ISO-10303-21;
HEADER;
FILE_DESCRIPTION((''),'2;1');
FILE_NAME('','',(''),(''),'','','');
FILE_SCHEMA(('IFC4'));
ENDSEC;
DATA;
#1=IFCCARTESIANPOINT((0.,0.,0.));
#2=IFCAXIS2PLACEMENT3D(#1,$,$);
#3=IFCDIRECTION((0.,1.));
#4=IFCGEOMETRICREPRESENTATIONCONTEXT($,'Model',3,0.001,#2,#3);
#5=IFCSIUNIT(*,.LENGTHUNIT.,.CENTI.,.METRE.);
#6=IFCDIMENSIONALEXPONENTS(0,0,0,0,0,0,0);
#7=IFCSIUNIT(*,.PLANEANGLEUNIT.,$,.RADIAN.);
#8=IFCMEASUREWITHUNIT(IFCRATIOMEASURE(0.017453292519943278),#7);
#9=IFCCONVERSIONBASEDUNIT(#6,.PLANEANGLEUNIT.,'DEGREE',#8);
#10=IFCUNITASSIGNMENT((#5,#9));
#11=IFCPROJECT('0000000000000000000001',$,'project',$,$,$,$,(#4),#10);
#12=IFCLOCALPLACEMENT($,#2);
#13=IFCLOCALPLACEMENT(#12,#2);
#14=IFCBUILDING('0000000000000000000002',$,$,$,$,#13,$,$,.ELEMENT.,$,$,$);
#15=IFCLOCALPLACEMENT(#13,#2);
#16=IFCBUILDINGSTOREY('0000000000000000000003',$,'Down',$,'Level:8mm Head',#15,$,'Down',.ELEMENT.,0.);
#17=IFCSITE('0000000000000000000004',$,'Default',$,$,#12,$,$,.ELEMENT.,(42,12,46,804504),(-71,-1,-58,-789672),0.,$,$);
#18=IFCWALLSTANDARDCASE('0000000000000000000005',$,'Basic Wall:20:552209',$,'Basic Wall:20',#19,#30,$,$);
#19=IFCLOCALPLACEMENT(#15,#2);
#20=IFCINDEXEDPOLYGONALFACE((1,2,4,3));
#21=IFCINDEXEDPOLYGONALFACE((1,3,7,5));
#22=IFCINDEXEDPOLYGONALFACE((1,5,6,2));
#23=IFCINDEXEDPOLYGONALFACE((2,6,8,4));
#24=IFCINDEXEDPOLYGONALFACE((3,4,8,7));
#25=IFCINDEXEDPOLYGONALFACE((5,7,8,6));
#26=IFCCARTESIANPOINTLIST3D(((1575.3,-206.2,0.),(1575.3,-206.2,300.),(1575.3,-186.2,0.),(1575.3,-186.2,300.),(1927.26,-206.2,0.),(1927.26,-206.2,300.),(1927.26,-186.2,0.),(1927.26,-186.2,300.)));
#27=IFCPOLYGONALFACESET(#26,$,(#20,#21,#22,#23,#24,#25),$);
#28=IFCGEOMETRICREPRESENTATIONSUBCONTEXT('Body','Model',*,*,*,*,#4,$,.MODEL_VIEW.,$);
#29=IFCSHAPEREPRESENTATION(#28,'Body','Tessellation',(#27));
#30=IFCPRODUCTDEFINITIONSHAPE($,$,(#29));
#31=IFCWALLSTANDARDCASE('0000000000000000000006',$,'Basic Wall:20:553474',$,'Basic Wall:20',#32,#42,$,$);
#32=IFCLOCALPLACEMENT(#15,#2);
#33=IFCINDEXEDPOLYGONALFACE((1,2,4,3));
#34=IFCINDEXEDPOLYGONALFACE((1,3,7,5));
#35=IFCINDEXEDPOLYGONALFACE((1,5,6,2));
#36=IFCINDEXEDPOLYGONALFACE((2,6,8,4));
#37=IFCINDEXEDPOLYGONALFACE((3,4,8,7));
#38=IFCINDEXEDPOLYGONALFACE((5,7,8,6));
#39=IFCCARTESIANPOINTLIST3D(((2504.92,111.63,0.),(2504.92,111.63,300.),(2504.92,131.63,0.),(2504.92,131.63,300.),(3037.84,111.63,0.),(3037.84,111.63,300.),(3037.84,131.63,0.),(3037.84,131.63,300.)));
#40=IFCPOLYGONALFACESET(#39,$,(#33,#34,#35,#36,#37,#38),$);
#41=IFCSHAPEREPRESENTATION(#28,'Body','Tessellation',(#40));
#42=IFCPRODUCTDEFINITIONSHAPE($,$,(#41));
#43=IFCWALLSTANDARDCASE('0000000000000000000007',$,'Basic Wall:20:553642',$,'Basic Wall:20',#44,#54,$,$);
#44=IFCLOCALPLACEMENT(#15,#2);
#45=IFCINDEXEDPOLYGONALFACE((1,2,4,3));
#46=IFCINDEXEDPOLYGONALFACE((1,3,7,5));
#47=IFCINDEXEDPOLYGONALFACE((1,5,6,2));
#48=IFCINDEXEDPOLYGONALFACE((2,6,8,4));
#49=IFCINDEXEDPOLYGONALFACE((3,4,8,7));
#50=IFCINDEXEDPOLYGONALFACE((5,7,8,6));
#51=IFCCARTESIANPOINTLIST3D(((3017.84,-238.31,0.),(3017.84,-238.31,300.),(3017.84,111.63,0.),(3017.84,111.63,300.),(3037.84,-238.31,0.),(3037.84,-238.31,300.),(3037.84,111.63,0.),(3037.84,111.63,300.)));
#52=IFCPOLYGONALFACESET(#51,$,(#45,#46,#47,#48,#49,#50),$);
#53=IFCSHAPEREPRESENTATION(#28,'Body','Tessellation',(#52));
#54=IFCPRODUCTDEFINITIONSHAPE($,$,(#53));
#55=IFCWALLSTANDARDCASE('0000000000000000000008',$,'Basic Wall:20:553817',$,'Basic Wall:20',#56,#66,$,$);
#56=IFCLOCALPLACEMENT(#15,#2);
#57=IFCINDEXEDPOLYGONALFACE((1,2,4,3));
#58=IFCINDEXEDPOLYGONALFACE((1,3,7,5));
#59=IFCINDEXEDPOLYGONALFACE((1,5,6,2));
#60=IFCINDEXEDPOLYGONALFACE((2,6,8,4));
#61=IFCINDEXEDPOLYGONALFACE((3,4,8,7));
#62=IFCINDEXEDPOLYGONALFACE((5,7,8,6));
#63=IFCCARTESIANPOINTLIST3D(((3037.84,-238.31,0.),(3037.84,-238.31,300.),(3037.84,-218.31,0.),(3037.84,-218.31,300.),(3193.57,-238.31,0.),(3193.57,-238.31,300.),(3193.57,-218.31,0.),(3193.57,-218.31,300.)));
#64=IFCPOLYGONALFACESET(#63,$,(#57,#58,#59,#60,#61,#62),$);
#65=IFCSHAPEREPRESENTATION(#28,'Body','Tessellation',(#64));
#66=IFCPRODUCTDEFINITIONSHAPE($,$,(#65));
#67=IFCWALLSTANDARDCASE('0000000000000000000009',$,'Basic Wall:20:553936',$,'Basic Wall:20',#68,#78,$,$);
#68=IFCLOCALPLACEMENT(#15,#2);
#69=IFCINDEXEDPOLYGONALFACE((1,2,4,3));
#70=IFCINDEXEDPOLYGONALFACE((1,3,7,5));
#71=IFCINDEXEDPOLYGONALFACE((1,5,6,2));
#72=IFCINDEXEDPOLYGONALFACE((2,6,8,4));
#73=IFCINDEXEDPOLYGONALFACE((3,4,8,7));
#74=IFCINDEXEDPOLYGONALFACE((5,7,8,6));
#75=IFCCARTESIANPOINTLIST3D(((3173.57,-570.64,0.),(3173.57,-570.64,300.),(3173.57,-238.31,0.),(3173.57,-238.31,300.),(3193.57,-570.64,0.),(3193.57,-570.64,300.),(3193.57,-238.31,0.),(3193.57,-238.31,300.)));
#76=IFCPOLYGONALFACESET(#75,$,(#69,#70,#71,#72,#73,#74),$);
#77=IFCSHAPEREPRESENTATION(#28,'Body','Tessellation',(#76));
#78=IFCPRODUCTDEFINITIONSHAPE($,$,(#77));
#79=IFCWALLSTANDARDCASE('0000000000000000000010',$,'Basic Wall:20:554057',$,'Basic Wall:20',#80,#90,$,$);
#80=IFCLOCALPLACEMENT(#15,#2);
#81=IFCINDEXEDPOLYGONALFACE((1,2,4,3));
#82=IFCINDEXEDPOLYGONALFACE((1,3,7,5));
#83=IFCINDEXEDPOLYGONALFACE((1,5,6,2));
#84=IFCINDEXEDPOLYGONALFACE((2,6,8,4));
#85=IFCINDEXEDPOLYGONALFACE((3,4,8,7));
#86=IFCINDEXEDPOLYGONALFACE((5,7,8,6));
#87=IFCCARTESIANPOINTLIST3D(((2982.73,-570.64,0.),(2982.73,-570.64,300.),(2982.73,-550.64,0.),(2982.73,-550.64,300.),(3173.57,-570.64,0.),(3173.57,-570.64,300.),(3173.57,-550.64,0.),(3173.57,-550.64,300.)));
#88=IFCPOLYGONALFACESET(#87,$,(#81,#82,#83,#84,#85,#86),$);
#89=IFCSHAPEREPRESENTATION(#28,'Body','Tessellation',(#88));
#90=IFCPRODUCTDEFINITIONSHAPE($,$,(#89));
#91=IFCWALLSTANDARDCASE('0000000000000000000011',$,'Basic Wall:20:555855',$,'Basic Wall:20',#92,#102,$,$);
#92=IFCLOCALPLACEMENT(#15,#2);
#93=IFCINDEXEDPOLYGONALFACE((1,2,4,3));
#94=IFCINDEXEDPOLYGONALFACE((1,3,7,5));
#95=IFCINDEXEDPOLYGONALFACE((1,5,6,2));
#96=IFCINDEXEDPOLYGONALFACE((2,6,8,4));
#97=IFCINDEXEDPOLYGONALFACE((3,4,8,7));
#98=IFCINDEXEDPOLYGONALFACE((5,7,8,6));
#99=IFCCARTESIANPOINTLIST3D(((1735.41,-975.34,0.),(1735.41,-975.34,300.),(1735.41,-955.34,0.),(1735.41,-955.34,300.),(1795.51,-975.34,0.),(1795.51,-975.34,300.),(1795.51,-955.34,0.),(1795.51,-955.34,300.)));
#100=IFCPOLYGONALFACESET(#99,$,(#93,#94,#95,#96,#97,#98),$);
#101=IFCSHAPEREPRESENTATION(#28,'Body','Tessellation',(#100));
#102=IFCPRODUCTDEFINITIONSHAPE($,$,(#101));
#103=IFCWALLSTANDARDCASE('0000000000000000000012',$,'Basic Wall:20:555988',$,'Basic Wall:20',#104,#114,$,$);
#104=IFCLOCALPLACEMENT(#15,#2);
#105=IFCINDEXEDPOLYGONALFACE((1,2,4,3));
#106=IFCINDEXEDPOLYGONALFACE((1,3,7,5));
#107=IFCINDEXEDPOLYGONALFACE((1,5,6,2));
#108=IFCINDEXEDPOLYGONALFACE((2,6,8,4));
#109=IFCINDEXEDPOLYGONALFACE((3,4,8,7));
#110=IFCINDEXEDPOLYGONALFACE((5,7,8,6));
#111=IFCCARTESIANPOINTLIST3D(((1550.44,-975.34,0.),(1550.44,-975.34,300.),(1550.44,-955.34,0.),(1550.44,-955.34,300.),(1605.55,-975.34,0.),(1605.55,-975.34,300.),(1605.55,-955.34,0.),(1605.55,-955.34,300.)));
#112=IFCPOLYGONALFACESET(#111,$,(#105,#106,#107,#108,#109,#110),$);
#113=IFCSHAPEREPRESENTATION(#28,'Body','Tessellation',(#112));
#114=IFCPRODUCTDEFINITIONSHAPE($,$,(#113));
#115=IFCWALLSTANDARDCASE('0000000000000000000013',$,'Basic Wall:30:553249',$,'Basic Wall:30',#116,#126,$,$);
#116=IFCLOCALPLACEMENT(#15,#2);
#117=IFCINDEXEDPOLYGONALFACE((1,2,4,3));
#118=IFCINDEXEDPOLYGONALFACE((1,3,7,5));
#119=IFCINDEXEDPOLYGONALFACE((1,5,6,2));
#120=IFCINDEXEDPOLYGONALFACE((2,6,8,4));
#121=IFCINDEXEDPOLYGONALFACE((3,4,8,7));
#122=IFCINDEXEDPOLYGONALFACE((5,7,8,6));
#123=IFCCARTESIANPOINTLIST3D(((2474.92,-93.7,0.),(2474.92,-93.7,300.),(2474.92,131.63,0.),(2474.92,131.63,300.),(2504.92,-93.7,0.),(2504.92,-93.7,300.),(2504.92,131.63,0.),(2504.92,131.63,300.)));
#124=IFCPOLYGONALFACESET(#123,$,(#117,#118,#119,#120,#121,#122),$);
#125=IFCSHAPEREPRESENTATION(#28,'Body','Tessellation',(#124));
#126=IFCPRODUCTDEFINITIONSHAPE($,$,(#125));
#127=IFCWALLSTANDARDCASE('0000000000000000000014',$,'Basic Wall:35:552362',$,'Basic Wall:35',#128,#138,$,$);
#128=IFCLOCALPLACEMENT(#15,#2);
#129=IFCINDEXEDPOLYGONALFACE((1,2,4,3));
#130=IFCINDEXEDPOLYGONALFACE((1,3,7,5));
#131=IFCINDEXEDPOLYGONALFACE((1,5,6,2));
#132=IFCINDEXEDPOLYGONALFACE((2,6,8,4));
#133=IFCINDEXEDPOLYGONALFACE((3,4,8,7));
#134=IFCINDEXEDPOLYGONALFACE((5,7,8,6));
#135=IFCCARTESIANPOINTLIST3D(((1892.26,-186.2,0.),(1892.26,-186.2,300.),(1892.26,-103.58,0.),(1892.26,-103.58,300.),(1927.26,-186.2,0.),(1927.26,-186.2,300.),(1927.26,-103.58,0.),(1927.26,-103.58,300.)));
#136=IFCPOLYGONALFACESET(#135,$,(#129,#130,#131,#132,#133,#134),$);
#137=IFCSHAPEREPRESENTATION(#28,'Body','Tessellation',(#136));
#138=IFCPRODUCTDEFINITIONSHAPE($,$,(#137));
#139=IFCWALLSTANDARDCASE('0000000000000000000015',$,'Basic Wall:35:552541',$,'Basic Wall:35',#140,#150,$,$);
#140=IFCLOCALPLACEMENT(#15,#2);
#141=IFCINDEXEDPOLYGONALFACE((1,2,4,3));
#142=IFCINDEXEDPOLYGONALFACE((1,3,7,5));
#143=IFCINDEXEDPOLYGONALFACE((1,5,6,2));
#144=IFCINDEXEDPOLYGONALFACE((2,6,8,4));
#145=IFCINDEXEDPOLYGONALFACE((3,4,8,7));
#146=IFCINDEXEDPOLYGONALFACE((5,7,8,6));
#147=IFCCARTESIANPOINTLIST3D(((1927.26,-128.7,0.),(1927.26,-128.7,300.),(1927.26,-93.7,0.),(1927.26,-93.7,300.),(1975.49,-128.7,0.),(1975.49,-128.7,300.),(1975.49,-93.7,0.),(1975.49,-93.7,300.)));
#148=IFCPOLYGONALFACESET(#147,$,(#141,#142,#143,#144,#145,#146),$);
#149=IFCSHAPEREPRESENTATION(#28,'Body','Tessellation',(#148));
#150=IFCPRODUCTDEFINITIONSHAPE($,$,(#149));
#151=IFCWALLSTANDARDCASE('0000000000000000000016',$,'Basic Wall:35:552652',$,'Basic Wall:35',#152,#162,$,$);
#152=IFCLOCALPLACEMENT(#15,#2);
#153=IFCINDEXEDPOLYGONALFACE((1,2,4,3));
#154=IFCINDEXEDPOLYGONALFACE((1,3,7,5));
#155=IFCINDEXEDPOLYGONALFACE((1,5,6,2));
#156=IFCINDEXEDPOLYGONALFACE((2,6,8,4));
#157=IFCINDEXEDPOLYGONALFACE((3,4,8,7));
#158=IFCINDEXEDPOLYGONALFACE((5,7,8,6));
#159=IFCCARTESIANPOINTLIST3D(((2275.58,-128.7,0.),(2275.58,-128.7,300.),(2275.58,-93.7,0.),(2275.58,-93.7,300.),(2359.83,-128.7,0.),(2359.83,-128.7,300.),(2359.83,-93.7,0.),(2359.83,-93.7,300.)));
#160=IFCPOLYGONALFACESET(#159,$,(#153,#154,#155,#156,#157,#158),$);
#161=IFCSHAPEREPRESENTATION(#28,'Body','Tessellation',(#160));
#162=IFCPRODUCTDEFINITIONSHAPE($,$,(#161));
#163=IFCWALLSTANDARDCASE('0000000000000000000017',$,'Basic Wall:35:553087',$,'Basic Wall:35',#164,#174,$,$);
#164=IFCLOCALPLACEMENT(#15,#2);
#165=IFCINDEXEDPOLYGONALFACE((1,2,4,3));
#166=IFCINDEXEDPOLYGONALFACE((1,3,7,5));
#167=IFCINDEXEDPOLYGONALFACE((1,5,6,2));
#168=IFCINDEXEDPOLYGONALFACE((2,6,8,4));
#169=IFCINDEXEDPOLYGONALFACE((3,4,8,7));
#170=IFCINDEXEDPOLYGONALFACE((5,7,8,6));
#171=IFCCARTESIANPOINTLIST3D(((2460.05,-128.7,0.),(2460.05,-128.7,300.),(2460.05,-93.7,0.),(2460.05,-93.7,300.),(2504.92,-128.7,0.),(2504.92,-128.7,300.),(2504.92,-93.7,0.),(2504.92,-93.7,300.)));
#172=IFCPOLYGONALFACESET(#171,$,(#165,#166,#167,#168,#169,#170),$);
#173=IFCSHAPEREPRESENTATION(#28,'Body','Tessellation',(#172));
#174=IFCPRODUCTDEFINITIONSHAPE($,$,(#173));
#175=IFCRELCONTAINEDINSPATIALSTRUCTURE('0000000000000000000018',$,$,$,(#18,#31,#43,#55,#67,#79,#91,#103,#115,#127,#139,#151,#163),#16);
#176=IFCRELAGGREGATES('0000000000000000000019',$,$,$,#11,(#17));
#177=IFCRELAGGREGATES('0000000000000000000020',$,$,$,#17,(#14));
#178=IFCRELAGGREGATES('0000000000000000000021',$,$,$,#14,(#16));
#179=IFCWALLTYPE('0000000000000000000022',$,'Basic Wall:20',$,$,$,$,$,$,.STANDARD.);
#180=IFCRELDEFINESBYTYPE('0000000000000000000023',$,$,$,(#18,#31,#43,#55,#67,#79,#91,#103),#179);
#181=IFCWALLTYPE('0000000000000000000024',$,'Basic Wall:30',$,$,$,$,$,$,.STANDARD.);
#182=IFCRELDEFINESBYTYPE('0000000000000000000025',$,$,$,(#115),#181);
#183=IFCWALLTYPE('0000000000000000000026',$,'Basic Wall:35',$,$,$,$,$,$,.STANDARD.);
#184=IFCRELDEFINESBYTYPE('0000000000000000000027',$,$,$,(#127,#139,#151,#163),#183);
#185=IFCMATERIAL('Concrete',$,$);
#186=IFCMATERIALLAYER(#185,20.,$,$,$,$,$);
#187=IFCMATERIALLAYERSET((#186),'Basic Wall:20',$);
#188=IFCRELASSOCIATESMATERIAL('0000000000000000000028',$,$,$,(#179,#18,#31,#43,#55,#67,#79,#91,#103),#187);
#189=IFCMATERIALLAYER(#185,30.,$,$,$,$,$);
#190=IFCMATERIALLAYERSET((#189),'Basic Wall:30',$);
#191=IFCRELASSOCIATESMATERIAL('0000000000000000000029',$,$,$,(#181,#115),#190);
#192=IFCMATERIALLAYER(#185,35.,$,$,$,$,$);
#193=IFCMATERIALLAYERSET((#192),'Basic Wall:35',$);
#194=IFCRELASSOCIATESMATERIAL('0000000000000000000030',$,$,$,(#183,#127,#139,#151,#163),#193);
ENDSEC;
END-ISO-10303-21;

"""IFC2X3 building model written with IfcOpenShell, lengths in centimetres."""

from ifc_helpers import new_model, entity, si_unit, converted_unit, direction, frame, frame_2d, origin, place, context, subcontext, project, spatial, rectangle, extrude, material, layer, layer_set, layer_usage, type_object, element, save


model = new_model("IFC2X3")

# Units and contexts
model_context = context("Model", 3, precision=0.001, world=origin(), true_north=direction((0.0, 1.0)))
body_context = subcontext(model_context, "Body", "Model", "MODEL_VIEW")
ifc_project = project(units=[si_unit("LENGTHUNIT", "METRE", prefix="CENTI"), converted_unit("PLANEANGLEUNIT", "DEGREE", entity("IfcRatioMeasure", 0.017453292519943278), si_unit("PLANEANGLEUNIT", "RADIAN"), dimensions=[0, 0, 0, 0, 0, 0, 0])], contexts=[model_context])

# Site, building, storey
site_placement = place(None, origin())
site = spatial("IfcSite", under=ifc_project, at=site_placement, Name="Default", CompositionType="ELEMENT", RefLatitude=(42, 12, 46, 804504), RefLongitude=(-71, -1, -58, -789672), RefElevation=0.0)
building_placement = place(site_placement, origin())
building = spatial("IfcBuilding", under=site, at=building_placement, CompositionType="ELEMENT")
storey_placement = place(building_placement, origin())
storey = spatial("IfcBuildingStorey", under=building, at=storey_placement, Name="Down", ObjectType="Level:8mm Head", LongName="Down", CompositionType="ELEMENT", Elevation=0.0)

# Walls
ifc_material = material(Name="Concrete")
ifc_layer_1 = layer(ifc_material, 20.0)
ifc_layer_set_1 = layer_set([ifc_layer_1], Name="Basic Wall:20")
ifc_layer_usage_1 = layer_usage(ifc_layer_set_1, "AXIS2", "POSITIVE", -10.0)
wall_type_1 = type_object("IfcWallType", Name="Basic Wall:20", PredefinedType="STANDARD", material=ifc_layer_set_1)
wall_1_placement = place(storey_placement, frame((1575.3, -196.2, 0.0)))
element("IfcWallStandardCase", 1, at=wall_1_placement, inside=storey, type_object=wall_type_1, material=ifc_layer_usage_1, Name="Basic Wall:20:552209", ObjectType="Basic Wall:20", context=body_context, shape_type="SweptSolid", body=[
    extrude(rectangle(XDim=351.96, YDim=20.0, at=frame_2d((175.98, 0.0), x_axis=(-1.0, 0.0))), origin(), (0.0, 0.0, 1.0), 300.0),
])
ifc_layer_usage_2 = layer_usage(ifc_layer_set_1, "AXIS2", "NEGATIVE", 10.0)
wall_2_placement = place(storey_placement, frame((2504.92, 121.63, 0.0)))
element("IfcWallStandardCase", 2, at=wall_2_placement, inside=storey, type_object=wall_type_1, material=ifc_layer_usage_2, Name="Basic Wall:20:553474", ObjectType="Basic Wall:20", context=body_context, shape_type="SweptSolid", body=[
    extrude(rectangle(XDim=532.92, YDim=20.0, at=frame_2d((266.46, 0.0), x_axis=(-1.0, 0.0))), origin(), (0.0, 0.0, 1.0), 300.0),
])
ifc_layer_usage_3 = layer_usage(ifc_layer_set_1, "AXIS2", "NEGATIVE", 10.0)
wall_3_placement = place(storey_placement, frame((3027.84, 111.63, 0.0), z_axis=(0.0, 0.0, 1.0), x_axis=(0.0, -1.0, 0.0)))
element("IfcWallStandardCase", 3, at=wall_3_placement, inside=storey, type_object=wall_type_1, material=ifc_layer_usage_3, Name="Basic Wall:20:553642", ObjectType="Basic Wall:20", context=body_context, shape_type="SweptSolid", body=[
    extrude(rectangle(XDim=349.94, YDim=20.0, at=frame_2d((174.97, 0.0), x_axis=(-1.0, 0.0))), origin(), (0.0, 0.0, 1.0), 300.0),
])
ifc_layer_usage_4 = layer_usage(ifc_layer_set_1, "AXIS2", "POSITIVE", -10.0)
wall_4_placement = place(storey_placement, frame((3037.84, -228.31, 0.0)))
element("IfcWallStandardCase", 4, at=wall_4_placement, inside=storey, type_object=wall_type_1, material=ifc_layer_usage_4, Name="Basic Wall:20:553817", ObjectType="Basic Wall:20", context=body_context, shape_type="SweptSolid", body=[
    extrude(rectangle(XDim=155.73, YDim=20.0, at=frame_2d((77.86, 0.0), x_axis=(-1.0, 0.0))), origin(), (0.0, 0.0, 1.0), 300.0),
])
ifc_layer_usage_5 = layer_usage(ifc_layer_set_1, "AXIS2", "NEGATIVE", 10.0)
wall_5_placement = place(storey_placement, frame((3183.57, -238.31, 0.0), z_axis=(0.0, 0.0, 1.0), x_axis=(0.0, -1.0, 0.0)))
element("IfcWallStandardCase", 5, at=wall_5_placement, inside=storey, type_object=wall_type_1, material=ifc_layer_usage_5, Name="Basic Wall:20:553936", ObjectType="Basic Wall:20", context=body_context, shape_type="SweptSolid", body=[
    extrude(rectangle(XDim=332.32, YDim=20.0, at=frame_2d((166.16, 0.0), x_axis=(-1.0, 0.0))), origin(), (0.0, 0.0, 1.0), 300.0),
])
ifc_layer_usage_6 = layer_usage(ifc_layer_set_1, "AXIS2", "NEGATIVE", 10.0)
wall_6_placement = place(storey_placement, frame((3173.57, -560.64, 0.0), z_axis=(0.0, 0.0, 1.0), x_axis=(-1.0, 0.0, 0.0)))
element("IfcWallStandardCase", 6, at=wall_6_placement, inside=storey, type_object=wall_type_1, material=ifc_layer_usage_6, Name="Basic Wall:20:554057", ObjectType="Basic Wall:20", context=body_context, shape_type="SweptSolid", body=[
    extrude(rectangle(XDim=190.84, YDim=20.0, at=frame_2d((95.42, 0.0), x_axis=(-1.0, 0.0))), origin(), (0.0, 0.0, 1.0), 300.0),
])
ifc_layer_usage_7 = layer_usage(ifc_layer_set_1, "AXIS2", "NEGATIVE", 10.0)
wall_7_placement = place(storey_placement, frame((1795.51, -965.34, 0.0), z_axis=(0.0, 0.0, 1.0), x_axis=(-1.0, 0.0, 0.0)))
element("IfcWallStandardCase", 7, at=wall_7_placement, inside=storey, type_object=wall_type_1, material=ifc_layer_usage_7, Name="Basic Wall:20:555855", ObjectType="Basic Wall:20", context=body_context, shape_type="SweptSolid", body=[
    extrude(rectangle(XDim=60.1, YDim=20.0, at=frame_2d((30.05, 0.0), x_axis=(-1.0, 0.0))), origin(), (0.0, 0.0, 1.0), 300.0),
])
ifc_layer_usage_8 = layer_usage(ifc_layer_set_1, "AXIS2", "POSITIVE", -10.0)
wall_8_placement = place(storey_placement, frame((1605.55, -965.34, 0.0), z_axis=(0.0, 0.0, 1.0), x_axis=(-1.0, 0.0, 0.0)))
element("IfcWallStandardCase", 8, at=wall_8_placement, inside=storey, type_object=wall_type_1, material=ifc_layer_usage_8, Name="Basic Wall:20:555988", ObjectType="Basic Wall:20", context=body_context, shape_type="SweptSolid", body=[
    extrude(rectangle(XDim=55.11, YDim=20.0, at=frame_2d((27.56, 0.0), x_axis=(-1.0, 0.0))), origin(), (0.0, 0.0, 1.0), 300.0),
])
ifc_layer_2 = layer(ifc_material, 30.0)
ifc_layer_set_2 = layer_set([ifc_layer_2], Name="Basic Wall:30")
ifc_layer_usage_9 = layer_usage(ifc_layer_set_2, "AXIS2", "POSITIVE", -15.0)
wall_type_2 = type_object("IfcWallType", Name="Basic Wall:30", PredefinedType="STANDARD", material=ifc_layer_set_2)
wall_9_placement = place(storey_placement, frame((2489.92, -93.7, 0.0), z_axis=(0.0, 0.0, 1.0), x_axis=(0.0, 1.0, 0.0)))
element("IfcWallStandardCase", 9, at=wall_9_placement, inside=storey, type_object=wall_type_2, material=ifc_layer_usage_9, Name="Basic Wall:30:553249", ObjectType="Basic Wall:30", context=body_context, shape_type="SweptSolid", body=[
    extrude(rectangle(XDim=225.33, YDim=30.0, at=frame_2d((112.67, 0.0), x_axis=(-1.0, 0.0))), origin(), (0.0, 0.0, 1.0), 300.0),
])
ifc_layer_3 = layer(ifc_material, 35.0)
ifc_layer_set_3 = layer_set([ifc_layer_3], Name="Basic Wall:35")
ifc_layer_usage_10 = layer_usage(ifc_layer_set_3, "AXIS2", "POSITIVE", -17.5)
wall_type_3 = type_object("IfcWallType", Name="Basic Wall:35", PredefinedType="STANDARD", material=ifc_layer_set_3)
wall_10_placement = place(storey_placement, frame((1909.76, -186.2, 0.0), z_axis=(0.0, 0.0, 1.0), x_axis=(0.0, 1.0, 0.0)))
element("IfcWallStandardCase", 10, at=wall_10_placement, inside=storey, type_object=wall_type_3, material=ifc_layer_usage_10, Name="Basic Wall:35:552362", ObjectType="Basic Wall:35", context=body_context, shape_type="SweptSolid", body=[
    extrude(rectangle(XDim=82.62, YDim=35.0, at=frame_2d((41.31, 0.0), x_axis=(-1.0, 0.0))), origin(), (0.0, 0.0, 1.0), 300.0),
])
ifc_layer_usage_11 = layer_usage(ifc_layer_set_3, "AXIS2", "POSITIVE", -17.5)
wall_11_placement = place(storey_placement, frame((1975.49, -111.2, 0.0), z_axis=(0.0, 0.0, 1.0), x_axis=(-1.0, 0.0, 0.0)))
element("IfcWallStandardCase", 11, at=wall_11_placement, inside=storey, type_object=wall_type_3, material=ifc_layer_usage_11, Name="Basic Wall:35:552541", ObjectType="Basic Wall:35", context=body_context, shape_type="SweptSolid", body=[
    extrude(rectangle(XDim=48.24, YDim=35.0, at=frame_2d((24.12, 0.0), x_axis=(-1.0, 0.0))), origin(), (0.0, 0.0, 1.0), 300.0),
])
ifc_layer_usage_12 = layer_usage(ifc_layer_set_3, "AXIS2", "NEGATIVE", 17.5)
wall_12_placement = place(storey_placement, frame((2275.58, -111.2, 0.0)))
element("IfcWallStandardCase", 12, at=wall_12_placement, inside=storey, type_object=wall_type_3, material=ifc_layer_usage_12, Name="Basic Wall:35:552652", ObjectType="Basic Wall:35", context=body_context, shape_type="SweptSolid", body=[
    extrude(rectangle(XDim=84.25, YDim=35.0, at=frame_2d((42.12, 0.0), x_axis=(-1.0, 0.0))), origin(), (0.0, 0.0, 1.0), 300.0),
])
ifc_layer_usage_13 = layer_usage(ifc_layer_set_3, "AXIS2", "NEGATIVE", 17.5)
wall_13_placement = place(storey_placement, frame((2504.92, -111.2, 0.0), z_axis=(0.0, 0.0, 1.0), x_axis=(-1.0, 0.0, 0.0)))
element("IfcWallStandardCase", 13, at=wall_13_placement, inside=storey, type_object=wall_type_3, material=ifc_layer_usage_13, Name="Basic Wall:35:553087", ObjectType="Basic Wall:35", context=body_context, shape_type="SweptSolid", body=[
    extrude(rectangle(XDim=44.87, YDim=35.0, at=frame_2d((22.43, 0.0), x_axis=(-1.0, 0.0))), origin(), (0.0, 0.0, 1.0), 300.0),
])

save(model, "model.ifc")
